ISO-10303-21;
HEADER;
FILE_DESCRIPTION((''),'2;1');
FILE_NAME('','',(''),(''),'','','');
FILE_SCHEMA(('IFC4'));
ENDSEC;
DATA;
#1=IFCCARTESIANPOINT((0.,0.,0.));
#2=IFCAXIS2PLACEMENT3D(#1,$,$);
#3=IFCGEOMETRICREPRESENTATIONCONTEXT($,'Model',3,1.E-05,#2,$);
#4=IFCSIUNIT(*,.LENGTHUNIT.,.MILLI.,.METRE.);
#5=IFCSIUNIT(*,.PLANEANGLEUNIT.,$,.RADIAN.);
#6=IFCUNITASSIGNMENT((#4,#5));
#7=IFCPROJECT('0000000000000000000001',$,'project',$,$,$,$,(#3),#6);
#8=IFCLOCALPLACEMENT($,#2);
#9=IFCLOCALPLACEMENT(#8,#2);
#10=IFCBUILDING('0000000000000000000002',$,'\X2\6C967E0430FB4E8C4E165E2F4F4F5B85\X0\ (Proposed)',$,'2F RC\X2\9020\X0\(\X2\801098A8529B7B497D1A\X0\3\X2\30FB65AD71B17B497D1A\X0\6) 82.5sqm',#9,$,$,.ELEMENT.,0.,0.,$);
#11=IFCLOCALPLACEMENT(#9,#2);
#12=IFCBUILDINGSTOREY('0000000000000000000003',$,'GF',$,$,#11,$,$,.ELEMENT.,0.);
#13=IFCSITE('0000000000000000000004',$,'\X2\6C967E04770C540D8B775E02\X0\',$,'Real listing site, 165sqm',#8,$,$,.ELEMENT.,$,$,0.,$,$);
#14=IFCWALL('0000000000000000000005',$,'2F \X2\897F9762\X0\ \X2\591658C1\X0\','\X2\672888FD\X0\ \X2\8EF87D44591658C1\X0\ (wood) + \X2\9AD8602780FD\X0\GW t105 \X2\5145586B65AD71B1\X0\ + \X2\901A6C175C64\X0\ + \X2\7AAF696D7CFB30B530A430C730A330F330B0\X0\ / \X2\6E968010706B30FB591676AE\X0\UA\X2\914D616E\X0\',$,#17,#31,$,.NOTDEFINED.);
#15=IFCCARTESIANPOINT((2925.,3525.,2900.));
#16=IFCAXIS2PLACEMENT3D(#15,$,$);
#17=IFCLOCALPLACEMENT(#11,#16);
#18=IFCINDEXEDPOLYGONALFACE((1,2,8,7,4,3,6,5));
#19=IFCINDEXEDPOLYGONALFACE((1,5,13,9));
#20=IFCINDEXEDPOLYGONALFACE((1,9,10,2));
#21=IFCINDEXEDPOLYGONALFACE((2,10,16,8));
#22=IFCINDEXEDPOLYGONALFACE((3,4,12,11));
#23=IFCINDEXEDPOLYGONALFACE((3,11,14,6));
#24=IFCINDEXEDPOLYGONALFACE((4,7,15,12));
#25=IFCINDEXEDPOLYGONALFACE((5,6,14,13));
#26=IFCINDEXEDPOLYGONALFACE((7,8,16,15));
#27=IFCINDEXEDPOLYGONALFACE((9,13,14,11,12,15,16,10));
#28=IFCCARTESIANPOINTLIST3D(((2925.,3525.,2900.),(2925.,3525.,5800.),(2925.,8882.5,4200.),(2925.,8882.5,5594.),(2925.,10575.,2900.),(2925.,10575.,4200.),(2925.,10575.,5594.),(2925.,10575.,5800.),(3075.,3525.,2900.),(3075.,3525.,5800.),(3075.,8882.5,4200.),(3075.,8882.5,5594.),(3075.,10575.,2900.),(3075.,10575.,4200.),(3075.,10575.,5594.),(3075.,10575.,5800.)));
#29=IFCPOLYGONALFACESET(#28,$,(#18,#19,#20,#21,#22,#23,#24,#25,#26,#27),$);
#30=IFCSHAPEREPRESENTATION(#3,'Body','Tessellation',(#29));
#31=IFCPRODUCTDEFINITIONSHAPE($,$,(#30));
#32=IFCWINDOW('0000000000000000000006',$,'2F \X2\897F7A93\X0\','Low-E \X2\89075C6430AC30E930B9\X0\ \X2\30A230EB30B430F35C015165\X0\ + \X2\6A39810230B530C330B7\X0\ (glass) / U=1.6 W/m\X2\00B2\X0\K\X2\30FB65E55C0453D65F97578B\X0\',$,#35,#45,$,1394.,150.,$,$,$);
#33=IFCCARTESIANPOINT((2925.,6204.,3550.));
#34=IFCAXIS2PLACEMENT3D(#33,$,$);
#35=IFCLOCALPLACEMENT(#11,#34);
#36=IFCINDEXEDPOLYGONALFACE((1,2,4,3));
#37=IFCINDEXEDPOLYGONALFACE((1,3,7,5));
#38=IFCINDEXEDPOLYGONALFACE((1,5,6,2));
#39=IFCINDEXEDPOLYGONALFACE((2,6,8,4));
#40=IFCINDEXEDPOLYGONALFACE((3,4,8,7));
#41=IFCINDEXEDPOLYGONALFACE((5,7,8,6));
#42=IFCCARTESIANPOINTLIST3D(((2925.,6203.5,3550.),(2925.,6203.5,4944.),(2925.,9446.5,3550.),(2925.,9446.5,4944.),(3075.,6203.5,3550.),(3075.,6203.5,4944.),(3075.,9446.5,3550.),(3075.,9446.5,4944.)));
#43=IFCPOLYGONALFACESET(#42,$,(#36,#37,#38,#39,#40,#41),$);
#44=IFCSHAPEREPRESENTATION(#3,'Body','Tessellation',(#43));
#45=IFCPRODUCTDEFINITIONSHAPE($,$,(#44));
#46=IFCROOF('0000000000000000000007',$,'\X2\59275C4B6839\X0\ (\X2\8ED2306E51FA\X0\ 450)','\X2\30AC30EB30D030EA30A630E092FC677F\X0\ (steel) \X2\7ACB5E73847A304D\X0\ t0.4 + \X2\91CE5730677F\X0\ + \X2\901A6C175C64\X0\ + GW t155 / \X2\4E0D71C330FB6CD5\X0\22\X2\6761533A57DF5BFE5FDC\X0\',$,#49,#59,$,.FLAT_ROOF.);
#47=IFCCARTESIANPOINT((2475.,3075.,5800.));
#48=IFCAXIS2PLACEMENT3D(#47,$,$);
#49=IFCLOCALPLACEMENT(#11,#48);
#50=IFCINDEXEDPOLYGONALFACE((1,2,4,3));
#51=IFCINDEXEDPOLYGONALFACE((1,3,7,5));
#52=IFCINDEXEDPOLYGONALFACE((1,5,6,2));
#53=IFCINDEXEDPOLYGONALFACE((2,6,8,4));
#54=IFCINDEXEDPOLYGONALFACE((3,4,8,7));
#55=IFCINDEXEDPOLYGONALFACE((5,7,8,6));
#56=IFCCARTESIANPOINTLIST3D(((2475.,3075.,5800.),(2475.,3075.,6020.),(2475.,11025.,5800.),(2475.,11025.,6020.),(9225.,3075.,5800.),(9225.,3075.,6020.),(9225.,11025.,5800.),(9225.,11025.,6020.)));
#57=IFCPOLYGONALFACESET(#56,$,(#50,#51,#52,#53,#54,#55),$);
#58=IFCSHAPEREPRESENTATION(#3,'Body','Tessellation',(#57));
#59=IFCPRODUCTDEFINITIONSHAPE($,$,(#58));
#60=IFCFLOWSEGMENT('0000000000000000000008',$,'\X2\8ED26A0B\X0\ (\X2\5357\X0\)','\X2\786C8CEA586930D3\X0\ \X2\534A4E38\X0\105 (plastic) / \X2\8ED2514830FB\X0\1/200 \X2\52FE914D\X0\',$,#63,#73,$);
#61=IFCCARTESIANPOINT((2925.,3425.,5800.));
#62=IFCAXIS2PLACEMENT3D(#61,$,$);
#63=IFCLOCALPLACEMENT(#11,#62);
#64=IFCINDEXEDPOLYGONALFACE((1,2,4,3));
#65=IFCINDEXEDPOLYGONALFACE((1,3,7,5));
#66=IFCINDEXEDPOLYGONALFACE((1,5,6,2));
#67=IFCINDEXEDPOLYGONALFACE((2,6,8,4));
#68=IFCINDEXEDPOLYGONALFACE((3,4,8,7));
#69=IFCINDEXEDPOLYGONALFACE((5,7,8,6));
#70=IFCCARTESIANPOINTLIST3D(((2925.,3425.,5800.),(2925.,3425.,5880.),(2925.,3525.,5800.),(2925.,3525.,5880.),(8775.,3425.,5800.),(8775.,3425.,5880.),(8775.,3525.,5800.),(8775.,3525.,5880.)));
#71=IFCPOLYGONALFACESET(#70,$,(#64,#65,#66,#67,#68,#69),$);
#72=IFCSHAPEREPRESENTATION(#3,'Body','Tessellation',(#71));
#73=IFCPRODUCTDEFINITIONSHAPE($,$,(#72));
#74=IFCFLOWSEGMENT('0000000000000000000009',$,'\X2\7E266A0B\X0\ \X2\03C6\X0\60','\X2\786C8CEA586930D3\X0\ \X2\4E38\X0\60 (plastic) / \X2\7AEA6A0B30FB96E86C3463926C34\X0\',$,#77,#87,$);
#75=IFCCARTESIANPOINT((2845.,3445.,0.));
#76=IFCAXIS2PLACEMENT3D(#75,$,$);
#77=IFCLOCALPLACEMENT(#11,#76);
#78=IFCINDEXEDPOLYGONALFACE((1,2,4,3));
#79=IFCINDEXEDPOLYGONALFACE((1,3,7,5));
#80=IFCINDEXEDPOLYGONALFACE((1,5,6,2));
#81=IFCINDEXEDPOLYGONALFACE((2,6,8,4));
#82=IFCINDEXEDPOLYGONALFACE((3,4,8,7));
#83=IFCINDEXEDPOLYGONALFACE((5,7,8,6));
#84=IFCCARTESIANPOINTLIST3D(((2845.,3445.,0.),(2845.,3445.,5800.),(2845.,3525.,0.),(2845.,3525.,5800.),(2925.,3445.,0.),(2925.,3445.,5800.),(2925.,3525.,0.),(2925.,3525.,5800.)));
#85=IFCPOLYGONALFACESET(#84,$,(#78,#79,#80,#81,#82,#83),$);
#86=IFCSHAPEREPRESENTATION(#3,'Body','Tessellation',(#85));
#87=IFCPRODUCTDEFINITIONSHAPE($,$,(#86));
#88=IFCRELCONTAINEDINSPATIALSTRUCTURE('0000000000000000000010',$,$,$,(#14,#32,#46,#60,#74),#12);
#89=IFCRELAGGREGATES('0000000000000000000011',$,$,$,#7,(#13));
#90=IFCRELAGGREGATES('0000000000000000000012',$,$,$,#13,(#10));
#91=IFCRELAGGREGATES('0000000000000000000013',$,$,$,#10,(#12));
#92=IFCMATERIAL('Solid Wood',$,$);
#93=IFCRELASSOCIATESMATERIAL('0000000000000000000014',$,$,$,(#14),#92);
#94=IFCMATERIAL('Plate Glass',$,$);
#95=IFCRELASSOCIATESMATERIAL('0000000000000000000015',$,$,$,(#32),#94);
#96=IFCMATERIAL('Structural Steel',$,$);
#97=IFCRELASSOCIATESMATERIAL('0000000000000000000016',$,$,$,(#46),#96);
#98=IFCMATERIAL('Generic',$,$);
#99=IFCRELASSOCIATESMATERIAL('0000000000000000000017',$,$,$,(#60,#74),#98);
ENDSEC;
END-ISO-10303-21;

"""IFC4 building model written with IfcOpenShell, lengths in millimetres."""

from ifc_helpers import new_model, si_unit, frame, frame_2d, origin, place, context, project, spatial, rectangle, extrude, material, element, fill, save


model = new_model("IFC4")

# Units and contexts
model_context = context("Model", 3, precision=1e-05, world=origin())
ifc_project = project(units=[si_unit("LENGTHUNIT", "METRE", prefix="MILLI"), si_unit("PLANEANGLEUNIT", "RADIAN")], contexts=[model_context])

# Site, building, storey
site_placement = place(None, origin())
site = spatial("IfcSite", under=ifc_project, at=site_placement, Name="沖縄県名護市", ObjectType="Real listing site, 165sqm", CompositionType="ELEMENT", RefElevation=0.0)
building_placement = place(site_placement, origin())
building = spatial("IfcBuilding", under=site, at=building_placement, Name="沖縄・二世帯住宅 (Proposed)", ObjectType="2F RC造(耐風力等級3・断熱等級6) 82.5sqm", CompositionType="ELEMENT", ElevationOfRefHeight=0.0, ElevationOfTerrain=0.0)
storey_placement = place(building_placement, origin())
storey = spatial("IfcBuildingStorey", under=building, at=storey_placement, Name="GF", CompositionType="ELEMENT", Elevation=0.0)

# Shared definitions
ifc_material_1 = material(Name="Solid Wood")

# Shared definitions
ifc_material_2 = material(Name="Plate Glass")

# Wall, opening, window
wall_1_placement = place(storey_placement, frame((2925.0, 3525.0, 2900.0)))
wall_1 = element("IfcWall", 1, at=wall_1_placement, inside=storey, material=ifc_material_1, Name="2F 西面 外壁", Description="木製 軸組外壁 (wood) + 高性能GW t105 充填断熱 + 通気層 + 窯業系サイディング / 準耐火・外皮UA配慮", PredefinedType="NOTDEFINED", context=model_context, shape_type="SweptSolid", body=[
    extrude(rectangle(XDim=150.0, YDim=7050.0, at=frame_2d((75.0, 3525.0))), frame((2925.0, 3525.0, 2900.0)), (0.0, 0.0, 1.0), 2900.0),
])
opening_1_placement = place(storey_placement, frame((2925.0, 6204.0, 3550.0)))
opening_1 = element("IfcOpeningElement", 2, at=opening_1_placement, cuts=wall_1, PredefinedType="NOTDEFINED", context=model_context, shape_type="SweptSolid", body=[
    extrude(rectangle(XDim=150.0, YDim=3243.0, at=frame_2d((75.0, 1621.0))), frame((2925.0, 6204.0, 3550.0)), (0.0, 0.0, 1.0), 1394.0),
])
window_1_placement = place(storey_placement, frame((2925.0, 6204.0, 3550.0)))
window_1 = element("IfcWindow", 3, at=window_1_placement, inside=storey, material=ifc_material_2, Name="2F 西窓", Description="Low-E 複層ガラス アルゴン封入 + 樹脂サッシ (glass) / U=1.6 W/m²K・日射取得型", OverallHeight=1394.0, OverallWidth=150.0, context=model_context, shape_type="SweptSolid", body=[
    extrude(rectangle(XDim=150.0, YDim=3243.0, at=frame_2d((75.0, 1621.0))), frame((2925.0, 6204.0, 3550.0)), (0.0, 0.0, 1.0), 1394.0),
])
fill(opening_1, window_1)

# Roof
ifc_material_3 = material(Name="Structural Steel")
roof_placement = place(storey_placement, frame((2475.0, 3075.0, 5800.0)))
element("IfcRoof", 4, at=roof_placement, inside=storey, material=ifc_material_3, Name="大屋根 (軒の出 450)", Description="ガルバリウム鋼板 (steel) 立平葺き t0.4 + 野地板 + 通気層 + GW t155 / 不燃・法22条区域対応", PredefinedType="FLAT_ROOF", context=model_context, shape_type="SweptSolid", body=[
    extrude(rectangle(XDim=6750.0, YDim=7950.0, at=frame_2d((3375.0, 3975.0))), frame((2475.0, 3075.0, 5800.0)), (0.0, 0.0, 1.0), 220.0),
])

# Flow segments
ifc_material_4 = material(Name="Generic")
flow_segment_1_placement = place(storey_placement, frame((2925.0, 3425.0, 5800.0)))
element("IfcFlowSegment", 5, at=flow_segment_1_placement, inside=storey, material=ifc_material_4, Name="軒樋 (南)", Description="硬質塩ビ 半丸105 (plastic) / 軒先・1/200 勾配", context=model_context, shape_type="SweptSolid", body=[
    extrude(rectangle(XDim=5850.0, YDim=100.0, at=frame_2d((2925.0, 50.0))), frame((2925.0, 3425.0, 5800.0)), (0.0, 0.0, 1.0), 80.0),
])
flow_segment_2_placement = place(storey_placement, frame((2845.0, 3445.0, 0.0)))
element("IfcFlowSegment", 6, at=flow_segment_2_placement, inside=storey, material=ifc_material_4, Name="縦樋 φ60", Description="硬質塩ビ 丸60 (plastic) / 竪樋・雨水排水", context=model_context, shape_type="SweptSolid", body=[
    extrude(rectangle(XDim=80.0, YDim=80.0, at=frame_2d((40.0, 40.0))), frame((2845.0, 3445.0, 0.0)), (0.0, 0.0, 1.0), 5800.0),
])

save(model, "model.ifc")
